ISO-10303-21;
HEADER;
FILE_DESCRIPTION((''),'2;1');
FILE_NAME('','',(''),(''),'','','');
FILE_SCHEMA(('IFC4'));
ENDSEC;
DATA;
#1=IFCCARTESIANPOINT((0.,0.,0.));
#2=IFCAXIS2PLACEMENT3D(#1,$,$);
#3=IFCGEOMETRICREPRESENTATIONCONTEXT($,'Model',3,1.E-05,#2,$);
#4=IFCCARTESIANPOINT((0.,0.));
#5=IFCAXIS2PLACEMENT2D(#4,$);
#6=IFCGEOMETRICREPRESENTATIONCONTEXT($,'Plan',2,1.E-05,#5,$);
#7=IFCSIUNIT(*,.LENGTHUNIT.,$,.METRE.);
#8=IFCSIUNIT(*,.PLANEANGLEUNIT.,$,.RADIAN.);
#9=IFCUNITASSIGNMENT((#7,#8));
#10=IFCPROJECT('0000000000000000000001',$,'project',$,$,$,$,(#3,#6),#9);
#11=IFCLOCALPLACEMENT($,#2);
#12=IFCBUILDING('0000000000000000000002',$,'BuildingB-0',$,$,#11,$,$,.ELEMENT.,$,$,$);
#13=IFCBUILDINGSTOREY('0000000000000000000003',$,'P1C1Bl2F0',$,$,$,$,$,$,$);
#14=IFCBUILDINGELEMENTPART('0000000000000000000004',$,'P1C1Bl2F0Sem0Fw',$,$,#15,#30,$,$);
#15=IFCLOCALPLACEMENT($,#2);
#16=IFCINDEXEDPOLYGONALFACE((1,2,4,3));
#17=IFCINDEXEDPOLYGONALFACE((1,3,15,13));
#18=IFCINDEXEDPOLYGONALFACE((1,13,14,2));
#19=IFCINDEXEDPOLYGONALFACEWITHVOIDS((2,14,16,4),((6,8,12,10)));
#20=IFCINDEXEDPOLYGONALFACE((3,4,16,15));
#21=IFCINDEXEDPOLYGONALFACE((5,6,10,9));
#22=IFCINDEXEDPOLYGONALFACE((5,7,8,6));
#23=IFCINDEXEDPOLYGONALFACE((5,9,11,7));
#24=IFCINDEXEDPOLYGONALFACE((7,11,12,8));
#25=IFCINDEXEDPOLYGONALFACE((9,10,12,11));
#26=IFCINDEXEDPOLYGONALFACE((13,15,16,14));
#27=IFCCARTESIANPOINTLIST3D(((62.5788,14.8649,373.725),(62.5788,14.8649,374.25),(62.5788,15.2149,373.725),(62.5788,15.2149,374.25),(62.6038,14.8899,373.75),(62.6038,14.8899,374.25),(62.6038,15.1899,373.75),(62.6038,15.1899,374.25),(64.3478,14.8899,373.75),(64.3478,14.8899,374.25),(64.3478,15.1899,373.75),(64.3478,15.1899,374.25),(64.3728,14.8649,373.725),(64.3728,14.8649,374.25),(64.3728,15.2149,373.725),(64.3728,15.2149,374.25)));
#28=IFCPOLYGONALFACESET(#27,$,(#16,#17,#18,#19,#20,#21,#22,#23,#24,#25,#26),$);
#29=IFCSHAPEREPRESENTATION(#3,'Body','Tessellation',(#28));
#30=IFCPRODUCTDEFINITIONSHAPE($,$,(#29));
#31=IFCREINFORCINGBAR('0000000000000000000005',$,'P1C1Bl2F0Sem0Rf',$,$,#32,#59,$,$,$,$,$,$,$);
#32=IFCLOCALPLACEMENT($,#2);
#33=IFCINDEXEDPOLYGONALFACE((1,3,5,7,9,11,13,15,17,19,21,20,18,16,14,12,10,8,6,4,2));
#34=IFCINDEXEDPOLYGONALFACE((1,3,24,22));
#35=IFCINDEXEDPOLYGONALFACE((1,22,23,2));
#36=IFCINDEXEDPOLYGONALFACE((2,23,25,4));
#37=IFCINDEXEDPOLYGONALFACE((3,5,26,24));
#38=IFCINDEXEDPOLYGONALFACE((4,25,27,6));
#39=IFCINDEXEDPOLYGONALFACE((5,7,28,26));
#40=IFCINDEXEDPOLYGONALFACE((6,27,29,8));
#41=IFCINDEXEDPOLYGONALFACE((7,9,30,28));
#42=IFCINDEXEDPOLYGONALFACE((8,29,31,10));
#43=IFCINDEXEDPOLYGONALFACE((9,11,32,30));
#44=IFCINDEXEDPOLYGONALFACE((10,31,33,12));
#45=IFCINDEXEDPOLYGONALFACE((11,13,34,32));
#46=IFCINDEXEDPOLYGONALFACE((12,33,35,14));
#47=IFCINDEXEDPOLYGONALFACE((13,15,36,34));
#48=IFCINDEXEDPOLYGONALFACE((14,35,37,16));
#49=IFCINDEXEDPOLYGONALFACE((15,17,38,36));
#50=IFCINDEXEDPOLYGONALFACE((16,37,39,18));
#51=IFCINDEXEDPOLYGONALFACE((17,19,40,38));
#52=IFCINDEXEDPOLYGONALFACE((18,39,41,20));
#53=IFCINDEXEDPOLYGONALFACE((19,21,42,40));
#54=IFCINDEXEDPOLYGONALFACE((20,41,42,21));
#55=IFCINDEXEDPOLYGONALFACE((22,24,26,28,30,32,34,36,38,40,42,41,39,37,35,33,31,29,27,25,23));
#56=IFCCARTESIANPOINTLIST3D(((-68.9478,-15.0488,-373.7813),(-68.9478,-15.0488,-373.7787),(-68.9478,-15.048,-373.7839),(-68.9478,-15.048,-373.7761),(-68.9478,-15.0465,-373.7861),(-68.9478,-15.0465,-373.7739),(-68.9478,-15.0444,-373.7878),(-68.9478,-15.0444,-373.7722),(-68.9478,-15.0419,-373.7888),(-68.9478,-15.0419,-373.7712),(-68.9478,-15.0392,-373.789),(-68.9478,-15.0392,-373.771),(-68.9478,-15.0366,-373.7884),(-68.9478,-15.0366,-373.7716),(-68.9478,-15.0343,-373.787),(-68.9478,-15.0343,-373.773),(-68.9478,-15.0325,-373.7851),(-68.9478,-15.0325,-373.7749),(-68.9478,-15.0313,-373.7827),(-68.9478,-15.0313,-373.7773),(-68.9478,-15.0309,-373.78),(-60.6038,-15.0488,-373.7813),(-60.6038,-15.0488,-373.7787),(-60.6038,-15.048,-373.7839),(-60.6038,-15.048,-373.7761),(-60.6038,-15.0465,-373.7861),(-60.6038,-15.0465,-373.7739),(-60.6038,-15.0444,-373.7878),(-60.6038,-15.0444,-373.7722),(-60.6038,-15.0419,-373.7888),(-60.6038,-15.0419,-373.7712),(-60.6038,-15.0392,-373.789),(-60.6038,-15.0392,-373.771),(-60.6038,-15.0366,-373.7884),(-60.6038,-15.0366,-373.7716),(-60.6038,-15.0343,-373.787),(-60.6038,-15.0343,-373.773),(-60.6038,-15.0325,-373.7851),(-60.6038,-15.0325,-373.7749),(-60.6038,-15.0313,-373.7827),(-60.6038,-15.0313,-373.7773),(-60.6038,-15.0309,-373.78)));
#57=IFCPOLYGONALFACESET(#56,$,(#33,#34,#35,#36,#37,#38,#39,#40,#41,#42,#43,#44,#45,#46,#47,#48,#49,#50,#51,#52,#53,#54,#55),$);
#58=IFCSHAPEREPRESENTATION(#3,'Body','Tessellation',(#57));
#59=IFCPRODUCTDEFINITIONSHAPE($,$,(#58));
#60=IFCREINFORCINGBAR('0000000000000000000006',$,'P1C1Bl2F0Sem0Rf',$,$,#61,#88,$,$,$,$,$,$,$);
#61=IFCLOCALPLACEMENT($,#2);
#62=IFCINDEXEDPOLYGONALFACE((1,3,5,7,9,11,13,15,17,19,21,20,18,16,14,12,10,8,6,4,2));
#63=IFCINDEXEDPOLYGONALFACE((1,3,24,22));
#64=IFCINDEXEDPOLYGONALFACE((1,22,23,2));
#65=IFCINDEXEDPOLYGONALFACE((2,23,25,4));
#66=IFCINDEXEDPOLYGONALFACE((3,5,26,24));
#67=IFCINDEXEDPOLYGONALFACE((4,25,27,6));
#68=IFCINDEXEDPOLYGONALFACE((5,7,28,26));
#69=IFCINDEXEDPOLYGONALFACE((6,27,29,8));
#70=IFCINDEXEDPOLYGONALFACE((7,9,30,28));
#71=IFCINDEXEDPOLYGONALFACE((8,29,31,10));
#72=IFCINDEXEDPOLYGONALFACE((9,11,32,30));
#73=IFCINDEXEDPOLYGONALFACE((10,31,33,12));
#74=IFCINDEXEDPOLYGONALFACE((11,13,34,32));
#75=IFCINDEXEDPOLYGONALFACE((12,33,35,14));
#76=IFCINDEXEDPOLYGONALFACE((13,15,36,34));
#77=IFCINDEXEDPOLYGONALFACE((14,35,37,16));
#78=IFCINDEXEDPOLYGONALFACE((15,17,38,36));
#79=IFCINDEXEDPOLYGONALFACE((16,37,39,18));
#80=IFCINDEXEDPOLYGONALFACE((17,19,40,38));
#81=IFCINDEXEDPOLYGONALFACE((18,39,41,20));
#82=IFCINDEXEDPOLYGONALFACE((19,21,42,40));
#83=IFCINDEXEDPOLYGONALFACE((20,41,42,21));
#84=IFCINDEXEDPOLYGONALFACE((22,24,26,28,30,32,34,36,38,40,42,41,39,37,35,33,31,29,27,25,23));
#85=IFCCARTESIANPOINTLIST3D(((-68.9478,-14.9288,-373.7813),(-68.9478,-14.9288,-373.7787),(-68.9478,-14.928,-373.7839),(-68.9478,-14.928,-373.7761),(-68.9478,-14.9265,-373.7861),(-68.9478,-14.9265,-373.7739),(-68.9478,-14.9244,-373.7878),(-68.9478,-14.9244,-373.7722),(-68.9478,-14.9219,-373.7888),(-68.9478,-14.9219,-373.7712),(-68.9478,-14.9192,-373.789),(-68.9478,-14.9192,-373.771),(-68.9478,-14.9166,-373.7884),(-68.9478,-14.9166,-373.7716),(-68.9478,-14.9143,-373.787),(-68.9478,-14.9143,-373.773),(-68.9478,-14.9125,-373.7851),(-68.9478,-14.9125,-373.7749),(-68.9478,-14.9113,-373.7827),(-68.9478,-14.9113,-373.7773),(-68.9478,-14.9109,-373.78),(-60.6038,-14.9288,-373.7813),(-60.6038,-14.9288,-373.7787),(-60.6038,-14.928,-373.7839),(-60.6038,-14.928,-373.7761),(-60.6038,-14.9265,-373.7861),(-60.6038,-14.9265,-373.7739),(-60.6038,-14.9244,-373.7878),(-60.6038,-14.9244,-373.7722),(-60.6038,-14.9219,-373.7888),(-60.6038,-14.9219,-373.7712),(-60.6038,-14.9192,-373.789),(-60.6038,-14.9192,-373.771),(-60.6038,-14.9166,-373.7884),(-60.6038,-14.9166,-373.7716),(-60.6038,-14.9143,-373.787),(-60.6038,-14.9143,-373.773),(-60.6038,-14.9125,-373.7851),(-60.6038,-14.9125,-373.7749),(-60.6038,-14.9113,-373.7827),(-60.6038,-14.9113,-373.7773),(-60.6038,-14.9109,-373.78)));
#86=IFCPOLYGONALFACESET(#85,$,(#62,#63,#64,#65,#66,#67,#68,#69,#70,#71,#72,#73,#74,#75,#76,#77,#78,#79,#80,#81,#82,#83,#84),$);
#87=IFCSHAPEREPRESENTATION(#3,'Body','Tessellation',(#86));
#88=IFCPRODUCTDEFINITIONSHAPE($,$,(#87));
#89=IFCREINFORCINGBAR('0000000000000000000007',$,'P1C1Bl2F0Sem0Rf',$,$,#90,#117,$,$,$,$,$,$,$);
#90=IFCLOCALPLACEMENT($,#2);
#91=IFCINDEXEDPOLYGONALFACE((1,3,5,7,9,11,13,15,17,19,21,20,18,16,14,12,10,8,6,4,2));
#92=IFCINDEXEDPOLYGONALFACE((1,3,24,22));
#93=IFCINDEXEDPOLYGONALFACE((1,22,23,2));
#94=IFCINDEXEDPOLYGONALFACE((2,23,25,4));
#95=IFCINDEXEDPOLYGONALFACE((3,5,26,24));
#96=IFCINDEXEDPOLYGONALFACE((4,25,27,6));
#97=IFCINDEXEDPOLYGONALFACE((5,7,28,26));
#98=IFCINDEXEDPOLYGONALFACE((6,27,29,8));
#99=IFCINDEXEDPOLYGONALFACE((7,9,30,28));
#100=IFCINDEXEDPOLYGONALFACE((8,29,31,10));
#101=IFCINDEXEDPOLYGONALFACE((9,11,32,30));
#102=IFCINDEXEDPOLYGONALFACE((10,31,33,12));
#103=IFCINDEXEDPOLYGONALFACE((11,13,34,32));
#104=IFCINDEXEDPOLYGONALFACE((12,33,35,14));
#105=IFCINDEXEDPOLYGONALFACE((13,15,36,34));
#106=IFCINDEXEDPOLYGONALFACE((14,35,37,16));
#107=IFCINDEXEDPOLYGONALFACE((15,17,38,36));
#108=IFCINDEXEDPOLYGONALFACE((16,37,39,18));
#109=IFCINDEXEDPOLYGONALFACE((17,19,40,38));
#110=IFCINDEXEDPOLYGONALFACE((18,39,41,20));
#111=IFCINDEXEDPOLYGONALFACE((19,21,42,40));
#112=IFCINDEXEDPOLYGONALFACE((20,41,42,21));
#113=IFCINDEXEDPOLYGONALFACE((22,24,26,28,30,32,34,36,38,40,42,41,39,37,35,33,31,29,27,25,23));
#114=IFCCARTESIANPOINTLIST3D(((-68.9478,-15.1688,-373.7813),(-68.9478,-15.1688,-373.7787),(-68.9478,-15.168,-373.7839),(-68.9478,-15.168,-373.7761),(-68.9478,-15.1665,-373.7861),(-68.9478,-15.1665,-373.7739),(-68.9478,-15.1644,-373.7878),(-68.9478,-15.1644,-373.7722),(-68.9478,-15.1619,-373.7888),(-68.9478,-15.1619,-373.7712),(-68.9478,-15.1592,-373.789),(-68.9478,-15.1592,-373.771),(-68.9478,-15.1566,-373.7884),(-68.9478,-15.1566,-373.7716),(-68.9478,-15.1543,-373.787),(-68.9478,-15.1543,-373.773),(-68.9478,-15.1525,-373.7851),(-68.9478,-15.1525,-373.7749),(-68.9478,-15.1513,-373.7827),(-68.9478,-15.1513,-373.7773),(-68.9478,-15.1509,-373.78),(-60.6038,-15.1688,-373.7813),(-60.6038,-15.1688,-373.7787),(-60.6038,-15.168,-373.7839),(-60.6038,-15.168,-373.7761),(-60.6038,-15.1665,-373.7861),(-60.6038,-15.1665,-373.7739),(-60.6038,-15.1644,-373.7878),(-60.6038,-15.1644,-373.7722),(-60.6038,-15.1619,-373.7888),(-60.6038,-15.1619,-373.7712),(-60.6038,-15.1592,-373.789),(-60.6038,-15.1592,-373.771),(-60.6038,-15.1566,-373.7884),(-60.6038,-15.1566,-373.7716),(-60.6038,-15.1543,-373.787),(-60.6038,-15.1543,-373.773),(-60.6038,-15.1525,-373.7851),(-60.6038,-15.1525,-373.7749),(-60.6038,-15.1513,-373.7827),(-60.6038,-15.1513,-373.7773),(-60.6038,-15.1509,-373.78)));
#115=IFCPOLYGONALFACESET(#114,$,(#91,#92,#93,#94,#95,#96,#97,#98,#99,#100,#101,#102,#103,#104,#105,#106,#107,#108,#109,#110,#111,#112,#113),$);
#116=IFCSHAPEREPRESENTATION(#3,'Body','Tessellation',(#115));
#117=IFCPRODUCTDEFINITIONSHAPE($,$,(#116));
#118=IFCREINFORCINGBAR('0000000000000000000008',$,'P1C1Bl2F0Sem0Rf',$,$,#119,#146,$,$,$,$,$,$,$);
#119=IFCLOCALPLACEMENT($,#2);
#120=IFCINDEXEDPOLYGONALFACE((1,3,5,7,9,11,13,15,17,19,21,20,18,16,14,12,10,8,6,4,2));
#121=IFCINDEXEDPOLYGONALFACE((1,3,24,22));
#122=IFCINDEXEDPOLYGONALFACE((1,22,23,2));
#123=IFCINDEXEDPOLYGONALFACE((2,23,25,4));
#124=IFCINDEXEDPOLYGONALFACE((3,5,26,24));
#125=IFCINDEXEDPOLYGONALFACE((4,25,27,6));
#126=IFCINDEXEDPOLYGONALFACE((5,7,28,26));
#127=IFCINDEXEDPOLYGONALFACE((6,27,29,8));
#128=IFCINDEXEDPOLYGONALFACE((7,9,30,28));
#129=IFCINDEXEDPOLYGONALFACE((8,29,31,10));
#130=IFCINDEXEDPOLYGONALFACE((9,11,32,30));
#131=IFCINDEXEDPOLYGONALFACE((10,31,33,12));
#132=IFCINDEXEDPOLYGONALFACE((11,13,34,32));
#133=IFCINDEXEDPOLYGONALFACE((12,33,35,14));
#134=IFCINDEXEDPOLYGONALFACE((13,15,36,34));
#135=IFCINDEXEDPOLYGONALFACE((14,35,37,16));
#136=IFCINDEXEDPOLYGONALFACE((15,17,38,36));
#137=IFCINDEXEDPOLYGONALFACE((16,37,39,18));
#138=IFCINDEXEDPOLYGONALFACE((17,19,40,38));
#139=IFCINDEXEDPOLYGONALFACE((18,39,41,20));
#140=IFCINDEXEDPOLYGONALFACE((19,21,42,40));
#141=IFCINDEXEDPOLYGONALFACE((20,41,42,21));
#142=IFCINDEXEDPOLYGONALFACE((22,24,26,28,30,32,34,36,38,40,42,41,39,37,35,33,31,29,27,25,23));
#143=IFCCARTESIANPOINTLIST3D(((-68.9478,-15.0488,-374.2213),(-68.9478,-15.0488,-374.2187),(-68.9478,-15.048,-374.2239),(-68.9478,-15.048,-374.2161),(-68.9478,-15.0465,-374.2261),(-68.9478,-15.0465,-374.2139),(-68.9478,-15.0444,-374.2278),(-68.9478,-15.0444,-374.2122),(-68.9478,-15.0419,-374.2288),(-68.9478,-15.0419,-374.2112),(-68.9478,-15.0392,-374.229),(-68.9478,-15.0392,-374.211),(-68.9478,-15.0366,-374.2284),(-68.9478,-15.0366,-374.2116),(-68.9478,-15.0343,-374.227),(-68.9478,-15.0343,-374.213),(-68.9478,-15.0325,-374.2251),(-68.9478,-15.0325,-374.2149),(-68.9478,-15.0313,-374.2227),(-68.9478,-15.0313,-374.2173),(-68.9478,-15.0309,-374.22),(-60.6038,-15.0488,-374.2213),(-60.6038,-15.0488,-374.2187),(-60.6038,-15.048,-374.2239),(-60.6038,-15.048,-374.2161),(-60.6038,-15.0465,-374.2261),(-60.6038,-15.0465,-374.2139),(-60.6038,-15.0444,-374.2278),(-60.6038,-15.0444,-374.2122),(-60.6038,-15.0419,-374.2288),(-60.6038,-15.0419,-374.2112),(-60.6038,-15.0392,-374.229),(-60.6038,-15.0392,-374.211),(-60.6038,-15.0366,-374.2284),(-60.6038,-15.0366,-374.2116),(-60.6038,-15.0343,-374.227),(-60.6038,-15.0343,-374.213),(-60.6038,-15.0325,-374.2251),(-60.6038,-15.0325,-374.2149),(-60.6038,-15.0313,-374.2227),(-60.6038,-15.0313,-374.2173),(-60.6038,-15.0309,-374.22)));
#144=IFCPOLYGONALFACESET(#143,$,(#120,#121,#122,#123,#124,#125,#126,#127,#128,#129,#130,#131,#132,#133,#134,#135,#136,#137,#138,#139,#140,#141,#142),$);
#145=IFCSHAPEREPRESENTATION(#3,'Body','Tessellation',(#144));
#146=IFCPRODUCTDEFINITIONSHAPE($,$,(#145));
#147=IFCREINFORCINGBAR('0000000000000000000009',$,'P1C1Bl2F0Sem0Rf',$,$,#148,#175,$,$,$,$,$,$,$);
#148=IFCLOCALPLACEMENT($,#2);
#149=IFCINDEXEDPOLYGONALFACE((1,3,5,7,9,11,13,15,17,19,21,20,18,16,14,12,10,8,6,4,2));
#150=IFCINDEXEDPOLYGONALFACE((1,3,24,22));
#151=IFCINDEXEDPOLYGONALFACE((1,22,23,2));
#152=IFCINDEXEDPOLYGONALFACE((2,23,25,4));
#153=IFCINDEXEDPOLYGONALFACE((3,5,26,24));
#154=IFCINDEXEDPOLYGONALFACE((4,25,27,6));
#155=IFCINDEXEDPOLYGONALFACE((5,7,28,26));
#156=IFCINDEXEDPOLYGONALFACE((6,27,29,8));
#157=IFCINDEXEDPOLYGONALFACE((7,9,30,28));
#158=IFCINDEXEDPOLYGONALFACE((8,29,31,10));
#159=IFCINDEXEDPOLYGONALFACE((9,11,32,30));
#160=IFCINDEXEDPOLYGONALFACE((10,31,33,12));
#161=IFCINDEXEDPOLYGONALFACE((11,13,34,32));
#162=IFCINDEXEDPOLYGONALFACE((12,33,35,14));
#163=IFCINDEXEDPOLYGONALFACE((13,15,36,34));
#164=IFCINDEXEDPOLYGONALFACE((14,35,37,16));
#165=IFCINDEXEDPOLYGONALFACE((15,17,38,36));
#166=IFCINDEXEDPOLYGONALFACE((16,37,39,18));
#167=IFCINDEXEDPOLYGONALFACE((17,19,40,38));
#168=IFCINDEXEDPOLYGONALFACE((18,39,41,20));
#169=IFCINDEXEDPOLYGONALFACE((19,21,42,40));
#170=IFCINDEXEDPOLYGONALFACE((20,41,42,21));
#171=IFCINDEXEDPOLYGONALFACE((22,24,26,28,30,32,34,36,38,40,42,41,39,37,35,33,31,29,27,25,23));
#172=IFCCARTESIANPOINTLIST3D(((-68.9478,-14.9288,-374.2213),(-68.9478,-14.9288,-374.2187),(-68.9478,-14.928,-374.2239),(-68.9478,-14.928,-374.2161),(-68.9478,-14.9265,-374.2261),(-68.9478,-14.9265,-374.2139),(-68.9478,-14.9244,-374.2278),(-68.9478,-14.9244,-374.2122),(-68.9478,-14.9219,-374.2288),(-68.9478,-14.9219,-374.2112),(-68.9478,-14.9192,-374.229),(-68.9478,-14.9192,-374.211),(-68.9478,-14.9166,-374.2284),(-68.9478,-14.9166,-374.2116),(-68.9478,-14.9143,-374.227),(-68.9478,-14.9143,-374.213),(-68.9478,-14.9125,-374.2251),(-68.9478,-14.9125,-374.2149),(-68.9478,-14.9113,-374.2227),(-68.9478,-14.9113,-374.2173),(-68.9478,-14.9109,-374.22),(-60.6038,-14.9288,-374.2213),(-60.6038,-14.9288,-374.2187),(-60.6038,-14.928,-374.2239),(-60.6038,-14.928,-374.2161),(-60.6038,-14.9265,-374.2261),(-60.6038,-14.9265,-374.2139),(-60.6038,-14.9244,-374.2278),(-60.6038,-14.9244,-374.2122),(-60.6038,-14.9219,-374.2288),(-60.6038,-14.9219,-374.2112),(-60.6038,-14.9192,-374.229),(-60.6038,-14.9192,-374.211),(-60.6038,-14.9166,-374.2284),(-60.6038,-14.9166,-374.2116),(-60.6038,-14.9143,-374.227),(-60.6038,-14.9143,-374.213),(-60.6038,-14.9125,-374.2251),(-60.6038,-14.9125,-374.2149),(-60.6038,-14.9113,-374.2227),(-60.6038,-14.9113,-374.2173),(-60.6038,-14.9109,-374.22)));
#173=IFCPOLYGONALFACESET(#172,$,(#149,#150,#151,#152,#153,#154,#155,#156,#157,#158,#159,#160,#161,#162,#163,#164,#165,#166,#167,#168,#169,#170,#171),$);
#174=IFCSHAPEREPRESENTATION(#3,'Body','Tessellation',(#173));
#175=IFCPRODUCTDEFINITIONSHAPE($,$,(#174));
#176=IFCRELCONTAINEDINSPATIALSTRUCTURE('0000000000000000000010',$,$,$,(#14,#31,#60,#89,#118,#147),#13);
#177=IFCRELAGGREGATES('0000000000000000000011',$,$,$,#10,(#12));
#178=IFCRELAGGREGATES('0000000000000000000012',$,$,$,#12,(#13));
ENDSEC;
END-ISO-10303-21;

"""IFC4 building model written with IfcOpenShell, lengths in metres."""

from ifc_helpers import new_model, entity, si_unit, origin, origin_2d, place, context, project, spatial, polyline, outline, extrude, element, save


model = new_model("IFC4")

# Units and contexts
model_context = context("Model", 3, precision=1e-05, world=origin())
plan_context = context("Plan", 2, precision=1e-05, world=origin_2d())
ifc_project = project(units=[si_unit("LENGTHUNIT", "METRE"), si_unit("PLANEANGLEUNIT", "RADIAN")], contexts=[model_context, plan_context])

# Building, storey
building_placement = place(None, origin())
building = spatial("IfcBuilding", under=ifc_project, at=building_placement, Name="BuildingB-0", CompositionType="ELEMENT")
storey = spatial("IfcBuildingStorey", under=building, Name="P1C1Bl2F0")

# Building element part, opening
building_element_part_1 = element("IfcBuildingElementPart", 1, inside=storey, Name="P1C1Bl2F0Sem0Fw", context=model_context, shape_type="SweptSolid", body=[
    extrude(outline(polyline([(64.3728, 14.8649, 373.725), (64.3728, 15.2149, 373.725), (62.5788, 15.2149, 373.725), (62.5788, 14.8649, 373.725), (64.3728, 14.8649, 373.725)])), None, (0.0, 0.0, 1.0), 0.525),
])
element("IfcOpeningElement", 2, inside=storey, cuts=building_element_part_1, context=model_context, shape_type="SweptSolid", body=[
    extrude(outline(polyline([(64.3478, 14.8899, 373.75), (64.3478, 15.1899, 373.75), (62.6038, 15.1899, 373.75), (62.6038, 14.8899, 373.75), (64.3478, 14.8899, 373.75)])), None, (0.0, 0.0, 1.0), 0.5),
])

# Reinforcing bars
element("IfcReinforcingBar", 3, inside=storey, Name="P1C1Bl2F0Sem0Rf", context=model_context, shape_type="SweptSolid", body=[
    entity("IfcSurfaceCurveSweptAreaSolid", entity("IfcCircleProfileDef", "AREA", None, None, 0.009), None, entity("IfcPolyline", [entity("IfcCartesianPoint", [60.6038, 15.0399, 373.78]), entity("IfcCartesianPoint", [68.9478, 15.0399, 373.78])]), None, None, entity("IfcPlane", entity("IfcAxis2Placement3D", entity("IfcCartesianPoint", [60.6038, 15.0399, 373.78]), entity("IfcDirection", [0.0, 0.0, 1.0]), entity("IfcDirection", [1.0, 0.0, 0.0])))),
])
element("IfcReinforcingBar", 4, inside=storey, Name="P1C1Bl2F0Sem0Rf", context=model_context, shape_type="SweptSolid", body=[
    entity("IfcSurfaceCurveSweptAreaSolid", entity("IfcCircleProfileDef", "AREA", None, None, 0.009), None, entity("IfcPolyline", [entity("IfcCartesianPoint", [60.6038, 14.9199, 373.78]), entity("IfcCartesianPoint", [68.9478, 14.9199, 373.78])]), None, None, entity("IfcPlane", entity("IfcAxis2Placement3D", entity("IfcCartesianPoint", [60.6038, 14.9199, 373.78]), entity("IfcDirection", [0.0, 0.0, 1.0]), entity("IfcDirection", [1.0, 0.0, 0.0])))),
])
element("IfcReinforcingBar", 5, inside=storey, Name="P1C1Bl2F0Sem0Rf", context=model_context, shape_type="SweptSolid", body=[
    entity("IfcSurfaceCurveSweptAreaSolid", entity("IfcCircleProfileDef", "AREA", None, None, 0.009), None, entity("IfcPolyline", [entity("IfcCartesianPoint", [60.6038, 15.1599, 373.78]), entity("IfcCartesianPoint", [68.9478, 15.1599, 373.78])]), None, None, entity("IfcPlane", entity("IfcAxis2Placement3D", entity("IfcCartesianPoint", [60.6038, 15.1599, 373.78]), entity("IfcDirection", [0.0, 0.0, 1.0]), entity("IfcDirection", [1.0, 0.0, 0.0])))),
])
element("IfcReinforcingBar", 6, inside=storey, Name="P1C1Bl2F0Sem0Rf", context=model_context, shape_type="SweptSolid", body=[
    entity("IfcSurfaceCurveSweptAreaSolid", entity("IfcCircleProfileDef", "AREA", None, None, 0.009), None, entity("IfcPolyline", [entity("IfcCartesianPoint", [60.6038, 15.0399, 374.22]), entity("IfcCartesianPoint", [68.9478, 15.0399, 374.22])]), None, None, entity("IfcPlane", entity("IfcAxis2Placement3D", entity("IfcCartesianPoint", [60.6038, 15.0399, 374.22]), entity("IfcDirection", [0.0, 0.0, 1.0]), entity("IfcDirection", [1.0, 0.0, 0.0])))),
])
element("IfcReinforcingBar", 7, inside=storey, Name="P1C1Bl2F0Sem0Rf", context=model_context, shape_type="SweptSolid", body=[
    entity("IfcSurfaceCurveSweptAreaSolid", entity("IfcCircleProfileDef", "AREA", None, None, 0.009), None, entity("IfcPolyline", [entity("IfcCartesianPoint", [60.6038, 14.9199, 374.22]), entity("IfcCartesianPoint", [68.9478, 14.9199, 374.22])]), None, None, entity("IfcPlane", entity("IfcAxis2Placement3D", entity("IfcCartesianPoint", [60.6038, 14.9199, 374.22]), entity("IfcDirection", [0.0, 0.0, 1.0]), entity("IfcDirection", [1.0, 0.0, 0.0])))),
])

save(model, "model.ifc")
